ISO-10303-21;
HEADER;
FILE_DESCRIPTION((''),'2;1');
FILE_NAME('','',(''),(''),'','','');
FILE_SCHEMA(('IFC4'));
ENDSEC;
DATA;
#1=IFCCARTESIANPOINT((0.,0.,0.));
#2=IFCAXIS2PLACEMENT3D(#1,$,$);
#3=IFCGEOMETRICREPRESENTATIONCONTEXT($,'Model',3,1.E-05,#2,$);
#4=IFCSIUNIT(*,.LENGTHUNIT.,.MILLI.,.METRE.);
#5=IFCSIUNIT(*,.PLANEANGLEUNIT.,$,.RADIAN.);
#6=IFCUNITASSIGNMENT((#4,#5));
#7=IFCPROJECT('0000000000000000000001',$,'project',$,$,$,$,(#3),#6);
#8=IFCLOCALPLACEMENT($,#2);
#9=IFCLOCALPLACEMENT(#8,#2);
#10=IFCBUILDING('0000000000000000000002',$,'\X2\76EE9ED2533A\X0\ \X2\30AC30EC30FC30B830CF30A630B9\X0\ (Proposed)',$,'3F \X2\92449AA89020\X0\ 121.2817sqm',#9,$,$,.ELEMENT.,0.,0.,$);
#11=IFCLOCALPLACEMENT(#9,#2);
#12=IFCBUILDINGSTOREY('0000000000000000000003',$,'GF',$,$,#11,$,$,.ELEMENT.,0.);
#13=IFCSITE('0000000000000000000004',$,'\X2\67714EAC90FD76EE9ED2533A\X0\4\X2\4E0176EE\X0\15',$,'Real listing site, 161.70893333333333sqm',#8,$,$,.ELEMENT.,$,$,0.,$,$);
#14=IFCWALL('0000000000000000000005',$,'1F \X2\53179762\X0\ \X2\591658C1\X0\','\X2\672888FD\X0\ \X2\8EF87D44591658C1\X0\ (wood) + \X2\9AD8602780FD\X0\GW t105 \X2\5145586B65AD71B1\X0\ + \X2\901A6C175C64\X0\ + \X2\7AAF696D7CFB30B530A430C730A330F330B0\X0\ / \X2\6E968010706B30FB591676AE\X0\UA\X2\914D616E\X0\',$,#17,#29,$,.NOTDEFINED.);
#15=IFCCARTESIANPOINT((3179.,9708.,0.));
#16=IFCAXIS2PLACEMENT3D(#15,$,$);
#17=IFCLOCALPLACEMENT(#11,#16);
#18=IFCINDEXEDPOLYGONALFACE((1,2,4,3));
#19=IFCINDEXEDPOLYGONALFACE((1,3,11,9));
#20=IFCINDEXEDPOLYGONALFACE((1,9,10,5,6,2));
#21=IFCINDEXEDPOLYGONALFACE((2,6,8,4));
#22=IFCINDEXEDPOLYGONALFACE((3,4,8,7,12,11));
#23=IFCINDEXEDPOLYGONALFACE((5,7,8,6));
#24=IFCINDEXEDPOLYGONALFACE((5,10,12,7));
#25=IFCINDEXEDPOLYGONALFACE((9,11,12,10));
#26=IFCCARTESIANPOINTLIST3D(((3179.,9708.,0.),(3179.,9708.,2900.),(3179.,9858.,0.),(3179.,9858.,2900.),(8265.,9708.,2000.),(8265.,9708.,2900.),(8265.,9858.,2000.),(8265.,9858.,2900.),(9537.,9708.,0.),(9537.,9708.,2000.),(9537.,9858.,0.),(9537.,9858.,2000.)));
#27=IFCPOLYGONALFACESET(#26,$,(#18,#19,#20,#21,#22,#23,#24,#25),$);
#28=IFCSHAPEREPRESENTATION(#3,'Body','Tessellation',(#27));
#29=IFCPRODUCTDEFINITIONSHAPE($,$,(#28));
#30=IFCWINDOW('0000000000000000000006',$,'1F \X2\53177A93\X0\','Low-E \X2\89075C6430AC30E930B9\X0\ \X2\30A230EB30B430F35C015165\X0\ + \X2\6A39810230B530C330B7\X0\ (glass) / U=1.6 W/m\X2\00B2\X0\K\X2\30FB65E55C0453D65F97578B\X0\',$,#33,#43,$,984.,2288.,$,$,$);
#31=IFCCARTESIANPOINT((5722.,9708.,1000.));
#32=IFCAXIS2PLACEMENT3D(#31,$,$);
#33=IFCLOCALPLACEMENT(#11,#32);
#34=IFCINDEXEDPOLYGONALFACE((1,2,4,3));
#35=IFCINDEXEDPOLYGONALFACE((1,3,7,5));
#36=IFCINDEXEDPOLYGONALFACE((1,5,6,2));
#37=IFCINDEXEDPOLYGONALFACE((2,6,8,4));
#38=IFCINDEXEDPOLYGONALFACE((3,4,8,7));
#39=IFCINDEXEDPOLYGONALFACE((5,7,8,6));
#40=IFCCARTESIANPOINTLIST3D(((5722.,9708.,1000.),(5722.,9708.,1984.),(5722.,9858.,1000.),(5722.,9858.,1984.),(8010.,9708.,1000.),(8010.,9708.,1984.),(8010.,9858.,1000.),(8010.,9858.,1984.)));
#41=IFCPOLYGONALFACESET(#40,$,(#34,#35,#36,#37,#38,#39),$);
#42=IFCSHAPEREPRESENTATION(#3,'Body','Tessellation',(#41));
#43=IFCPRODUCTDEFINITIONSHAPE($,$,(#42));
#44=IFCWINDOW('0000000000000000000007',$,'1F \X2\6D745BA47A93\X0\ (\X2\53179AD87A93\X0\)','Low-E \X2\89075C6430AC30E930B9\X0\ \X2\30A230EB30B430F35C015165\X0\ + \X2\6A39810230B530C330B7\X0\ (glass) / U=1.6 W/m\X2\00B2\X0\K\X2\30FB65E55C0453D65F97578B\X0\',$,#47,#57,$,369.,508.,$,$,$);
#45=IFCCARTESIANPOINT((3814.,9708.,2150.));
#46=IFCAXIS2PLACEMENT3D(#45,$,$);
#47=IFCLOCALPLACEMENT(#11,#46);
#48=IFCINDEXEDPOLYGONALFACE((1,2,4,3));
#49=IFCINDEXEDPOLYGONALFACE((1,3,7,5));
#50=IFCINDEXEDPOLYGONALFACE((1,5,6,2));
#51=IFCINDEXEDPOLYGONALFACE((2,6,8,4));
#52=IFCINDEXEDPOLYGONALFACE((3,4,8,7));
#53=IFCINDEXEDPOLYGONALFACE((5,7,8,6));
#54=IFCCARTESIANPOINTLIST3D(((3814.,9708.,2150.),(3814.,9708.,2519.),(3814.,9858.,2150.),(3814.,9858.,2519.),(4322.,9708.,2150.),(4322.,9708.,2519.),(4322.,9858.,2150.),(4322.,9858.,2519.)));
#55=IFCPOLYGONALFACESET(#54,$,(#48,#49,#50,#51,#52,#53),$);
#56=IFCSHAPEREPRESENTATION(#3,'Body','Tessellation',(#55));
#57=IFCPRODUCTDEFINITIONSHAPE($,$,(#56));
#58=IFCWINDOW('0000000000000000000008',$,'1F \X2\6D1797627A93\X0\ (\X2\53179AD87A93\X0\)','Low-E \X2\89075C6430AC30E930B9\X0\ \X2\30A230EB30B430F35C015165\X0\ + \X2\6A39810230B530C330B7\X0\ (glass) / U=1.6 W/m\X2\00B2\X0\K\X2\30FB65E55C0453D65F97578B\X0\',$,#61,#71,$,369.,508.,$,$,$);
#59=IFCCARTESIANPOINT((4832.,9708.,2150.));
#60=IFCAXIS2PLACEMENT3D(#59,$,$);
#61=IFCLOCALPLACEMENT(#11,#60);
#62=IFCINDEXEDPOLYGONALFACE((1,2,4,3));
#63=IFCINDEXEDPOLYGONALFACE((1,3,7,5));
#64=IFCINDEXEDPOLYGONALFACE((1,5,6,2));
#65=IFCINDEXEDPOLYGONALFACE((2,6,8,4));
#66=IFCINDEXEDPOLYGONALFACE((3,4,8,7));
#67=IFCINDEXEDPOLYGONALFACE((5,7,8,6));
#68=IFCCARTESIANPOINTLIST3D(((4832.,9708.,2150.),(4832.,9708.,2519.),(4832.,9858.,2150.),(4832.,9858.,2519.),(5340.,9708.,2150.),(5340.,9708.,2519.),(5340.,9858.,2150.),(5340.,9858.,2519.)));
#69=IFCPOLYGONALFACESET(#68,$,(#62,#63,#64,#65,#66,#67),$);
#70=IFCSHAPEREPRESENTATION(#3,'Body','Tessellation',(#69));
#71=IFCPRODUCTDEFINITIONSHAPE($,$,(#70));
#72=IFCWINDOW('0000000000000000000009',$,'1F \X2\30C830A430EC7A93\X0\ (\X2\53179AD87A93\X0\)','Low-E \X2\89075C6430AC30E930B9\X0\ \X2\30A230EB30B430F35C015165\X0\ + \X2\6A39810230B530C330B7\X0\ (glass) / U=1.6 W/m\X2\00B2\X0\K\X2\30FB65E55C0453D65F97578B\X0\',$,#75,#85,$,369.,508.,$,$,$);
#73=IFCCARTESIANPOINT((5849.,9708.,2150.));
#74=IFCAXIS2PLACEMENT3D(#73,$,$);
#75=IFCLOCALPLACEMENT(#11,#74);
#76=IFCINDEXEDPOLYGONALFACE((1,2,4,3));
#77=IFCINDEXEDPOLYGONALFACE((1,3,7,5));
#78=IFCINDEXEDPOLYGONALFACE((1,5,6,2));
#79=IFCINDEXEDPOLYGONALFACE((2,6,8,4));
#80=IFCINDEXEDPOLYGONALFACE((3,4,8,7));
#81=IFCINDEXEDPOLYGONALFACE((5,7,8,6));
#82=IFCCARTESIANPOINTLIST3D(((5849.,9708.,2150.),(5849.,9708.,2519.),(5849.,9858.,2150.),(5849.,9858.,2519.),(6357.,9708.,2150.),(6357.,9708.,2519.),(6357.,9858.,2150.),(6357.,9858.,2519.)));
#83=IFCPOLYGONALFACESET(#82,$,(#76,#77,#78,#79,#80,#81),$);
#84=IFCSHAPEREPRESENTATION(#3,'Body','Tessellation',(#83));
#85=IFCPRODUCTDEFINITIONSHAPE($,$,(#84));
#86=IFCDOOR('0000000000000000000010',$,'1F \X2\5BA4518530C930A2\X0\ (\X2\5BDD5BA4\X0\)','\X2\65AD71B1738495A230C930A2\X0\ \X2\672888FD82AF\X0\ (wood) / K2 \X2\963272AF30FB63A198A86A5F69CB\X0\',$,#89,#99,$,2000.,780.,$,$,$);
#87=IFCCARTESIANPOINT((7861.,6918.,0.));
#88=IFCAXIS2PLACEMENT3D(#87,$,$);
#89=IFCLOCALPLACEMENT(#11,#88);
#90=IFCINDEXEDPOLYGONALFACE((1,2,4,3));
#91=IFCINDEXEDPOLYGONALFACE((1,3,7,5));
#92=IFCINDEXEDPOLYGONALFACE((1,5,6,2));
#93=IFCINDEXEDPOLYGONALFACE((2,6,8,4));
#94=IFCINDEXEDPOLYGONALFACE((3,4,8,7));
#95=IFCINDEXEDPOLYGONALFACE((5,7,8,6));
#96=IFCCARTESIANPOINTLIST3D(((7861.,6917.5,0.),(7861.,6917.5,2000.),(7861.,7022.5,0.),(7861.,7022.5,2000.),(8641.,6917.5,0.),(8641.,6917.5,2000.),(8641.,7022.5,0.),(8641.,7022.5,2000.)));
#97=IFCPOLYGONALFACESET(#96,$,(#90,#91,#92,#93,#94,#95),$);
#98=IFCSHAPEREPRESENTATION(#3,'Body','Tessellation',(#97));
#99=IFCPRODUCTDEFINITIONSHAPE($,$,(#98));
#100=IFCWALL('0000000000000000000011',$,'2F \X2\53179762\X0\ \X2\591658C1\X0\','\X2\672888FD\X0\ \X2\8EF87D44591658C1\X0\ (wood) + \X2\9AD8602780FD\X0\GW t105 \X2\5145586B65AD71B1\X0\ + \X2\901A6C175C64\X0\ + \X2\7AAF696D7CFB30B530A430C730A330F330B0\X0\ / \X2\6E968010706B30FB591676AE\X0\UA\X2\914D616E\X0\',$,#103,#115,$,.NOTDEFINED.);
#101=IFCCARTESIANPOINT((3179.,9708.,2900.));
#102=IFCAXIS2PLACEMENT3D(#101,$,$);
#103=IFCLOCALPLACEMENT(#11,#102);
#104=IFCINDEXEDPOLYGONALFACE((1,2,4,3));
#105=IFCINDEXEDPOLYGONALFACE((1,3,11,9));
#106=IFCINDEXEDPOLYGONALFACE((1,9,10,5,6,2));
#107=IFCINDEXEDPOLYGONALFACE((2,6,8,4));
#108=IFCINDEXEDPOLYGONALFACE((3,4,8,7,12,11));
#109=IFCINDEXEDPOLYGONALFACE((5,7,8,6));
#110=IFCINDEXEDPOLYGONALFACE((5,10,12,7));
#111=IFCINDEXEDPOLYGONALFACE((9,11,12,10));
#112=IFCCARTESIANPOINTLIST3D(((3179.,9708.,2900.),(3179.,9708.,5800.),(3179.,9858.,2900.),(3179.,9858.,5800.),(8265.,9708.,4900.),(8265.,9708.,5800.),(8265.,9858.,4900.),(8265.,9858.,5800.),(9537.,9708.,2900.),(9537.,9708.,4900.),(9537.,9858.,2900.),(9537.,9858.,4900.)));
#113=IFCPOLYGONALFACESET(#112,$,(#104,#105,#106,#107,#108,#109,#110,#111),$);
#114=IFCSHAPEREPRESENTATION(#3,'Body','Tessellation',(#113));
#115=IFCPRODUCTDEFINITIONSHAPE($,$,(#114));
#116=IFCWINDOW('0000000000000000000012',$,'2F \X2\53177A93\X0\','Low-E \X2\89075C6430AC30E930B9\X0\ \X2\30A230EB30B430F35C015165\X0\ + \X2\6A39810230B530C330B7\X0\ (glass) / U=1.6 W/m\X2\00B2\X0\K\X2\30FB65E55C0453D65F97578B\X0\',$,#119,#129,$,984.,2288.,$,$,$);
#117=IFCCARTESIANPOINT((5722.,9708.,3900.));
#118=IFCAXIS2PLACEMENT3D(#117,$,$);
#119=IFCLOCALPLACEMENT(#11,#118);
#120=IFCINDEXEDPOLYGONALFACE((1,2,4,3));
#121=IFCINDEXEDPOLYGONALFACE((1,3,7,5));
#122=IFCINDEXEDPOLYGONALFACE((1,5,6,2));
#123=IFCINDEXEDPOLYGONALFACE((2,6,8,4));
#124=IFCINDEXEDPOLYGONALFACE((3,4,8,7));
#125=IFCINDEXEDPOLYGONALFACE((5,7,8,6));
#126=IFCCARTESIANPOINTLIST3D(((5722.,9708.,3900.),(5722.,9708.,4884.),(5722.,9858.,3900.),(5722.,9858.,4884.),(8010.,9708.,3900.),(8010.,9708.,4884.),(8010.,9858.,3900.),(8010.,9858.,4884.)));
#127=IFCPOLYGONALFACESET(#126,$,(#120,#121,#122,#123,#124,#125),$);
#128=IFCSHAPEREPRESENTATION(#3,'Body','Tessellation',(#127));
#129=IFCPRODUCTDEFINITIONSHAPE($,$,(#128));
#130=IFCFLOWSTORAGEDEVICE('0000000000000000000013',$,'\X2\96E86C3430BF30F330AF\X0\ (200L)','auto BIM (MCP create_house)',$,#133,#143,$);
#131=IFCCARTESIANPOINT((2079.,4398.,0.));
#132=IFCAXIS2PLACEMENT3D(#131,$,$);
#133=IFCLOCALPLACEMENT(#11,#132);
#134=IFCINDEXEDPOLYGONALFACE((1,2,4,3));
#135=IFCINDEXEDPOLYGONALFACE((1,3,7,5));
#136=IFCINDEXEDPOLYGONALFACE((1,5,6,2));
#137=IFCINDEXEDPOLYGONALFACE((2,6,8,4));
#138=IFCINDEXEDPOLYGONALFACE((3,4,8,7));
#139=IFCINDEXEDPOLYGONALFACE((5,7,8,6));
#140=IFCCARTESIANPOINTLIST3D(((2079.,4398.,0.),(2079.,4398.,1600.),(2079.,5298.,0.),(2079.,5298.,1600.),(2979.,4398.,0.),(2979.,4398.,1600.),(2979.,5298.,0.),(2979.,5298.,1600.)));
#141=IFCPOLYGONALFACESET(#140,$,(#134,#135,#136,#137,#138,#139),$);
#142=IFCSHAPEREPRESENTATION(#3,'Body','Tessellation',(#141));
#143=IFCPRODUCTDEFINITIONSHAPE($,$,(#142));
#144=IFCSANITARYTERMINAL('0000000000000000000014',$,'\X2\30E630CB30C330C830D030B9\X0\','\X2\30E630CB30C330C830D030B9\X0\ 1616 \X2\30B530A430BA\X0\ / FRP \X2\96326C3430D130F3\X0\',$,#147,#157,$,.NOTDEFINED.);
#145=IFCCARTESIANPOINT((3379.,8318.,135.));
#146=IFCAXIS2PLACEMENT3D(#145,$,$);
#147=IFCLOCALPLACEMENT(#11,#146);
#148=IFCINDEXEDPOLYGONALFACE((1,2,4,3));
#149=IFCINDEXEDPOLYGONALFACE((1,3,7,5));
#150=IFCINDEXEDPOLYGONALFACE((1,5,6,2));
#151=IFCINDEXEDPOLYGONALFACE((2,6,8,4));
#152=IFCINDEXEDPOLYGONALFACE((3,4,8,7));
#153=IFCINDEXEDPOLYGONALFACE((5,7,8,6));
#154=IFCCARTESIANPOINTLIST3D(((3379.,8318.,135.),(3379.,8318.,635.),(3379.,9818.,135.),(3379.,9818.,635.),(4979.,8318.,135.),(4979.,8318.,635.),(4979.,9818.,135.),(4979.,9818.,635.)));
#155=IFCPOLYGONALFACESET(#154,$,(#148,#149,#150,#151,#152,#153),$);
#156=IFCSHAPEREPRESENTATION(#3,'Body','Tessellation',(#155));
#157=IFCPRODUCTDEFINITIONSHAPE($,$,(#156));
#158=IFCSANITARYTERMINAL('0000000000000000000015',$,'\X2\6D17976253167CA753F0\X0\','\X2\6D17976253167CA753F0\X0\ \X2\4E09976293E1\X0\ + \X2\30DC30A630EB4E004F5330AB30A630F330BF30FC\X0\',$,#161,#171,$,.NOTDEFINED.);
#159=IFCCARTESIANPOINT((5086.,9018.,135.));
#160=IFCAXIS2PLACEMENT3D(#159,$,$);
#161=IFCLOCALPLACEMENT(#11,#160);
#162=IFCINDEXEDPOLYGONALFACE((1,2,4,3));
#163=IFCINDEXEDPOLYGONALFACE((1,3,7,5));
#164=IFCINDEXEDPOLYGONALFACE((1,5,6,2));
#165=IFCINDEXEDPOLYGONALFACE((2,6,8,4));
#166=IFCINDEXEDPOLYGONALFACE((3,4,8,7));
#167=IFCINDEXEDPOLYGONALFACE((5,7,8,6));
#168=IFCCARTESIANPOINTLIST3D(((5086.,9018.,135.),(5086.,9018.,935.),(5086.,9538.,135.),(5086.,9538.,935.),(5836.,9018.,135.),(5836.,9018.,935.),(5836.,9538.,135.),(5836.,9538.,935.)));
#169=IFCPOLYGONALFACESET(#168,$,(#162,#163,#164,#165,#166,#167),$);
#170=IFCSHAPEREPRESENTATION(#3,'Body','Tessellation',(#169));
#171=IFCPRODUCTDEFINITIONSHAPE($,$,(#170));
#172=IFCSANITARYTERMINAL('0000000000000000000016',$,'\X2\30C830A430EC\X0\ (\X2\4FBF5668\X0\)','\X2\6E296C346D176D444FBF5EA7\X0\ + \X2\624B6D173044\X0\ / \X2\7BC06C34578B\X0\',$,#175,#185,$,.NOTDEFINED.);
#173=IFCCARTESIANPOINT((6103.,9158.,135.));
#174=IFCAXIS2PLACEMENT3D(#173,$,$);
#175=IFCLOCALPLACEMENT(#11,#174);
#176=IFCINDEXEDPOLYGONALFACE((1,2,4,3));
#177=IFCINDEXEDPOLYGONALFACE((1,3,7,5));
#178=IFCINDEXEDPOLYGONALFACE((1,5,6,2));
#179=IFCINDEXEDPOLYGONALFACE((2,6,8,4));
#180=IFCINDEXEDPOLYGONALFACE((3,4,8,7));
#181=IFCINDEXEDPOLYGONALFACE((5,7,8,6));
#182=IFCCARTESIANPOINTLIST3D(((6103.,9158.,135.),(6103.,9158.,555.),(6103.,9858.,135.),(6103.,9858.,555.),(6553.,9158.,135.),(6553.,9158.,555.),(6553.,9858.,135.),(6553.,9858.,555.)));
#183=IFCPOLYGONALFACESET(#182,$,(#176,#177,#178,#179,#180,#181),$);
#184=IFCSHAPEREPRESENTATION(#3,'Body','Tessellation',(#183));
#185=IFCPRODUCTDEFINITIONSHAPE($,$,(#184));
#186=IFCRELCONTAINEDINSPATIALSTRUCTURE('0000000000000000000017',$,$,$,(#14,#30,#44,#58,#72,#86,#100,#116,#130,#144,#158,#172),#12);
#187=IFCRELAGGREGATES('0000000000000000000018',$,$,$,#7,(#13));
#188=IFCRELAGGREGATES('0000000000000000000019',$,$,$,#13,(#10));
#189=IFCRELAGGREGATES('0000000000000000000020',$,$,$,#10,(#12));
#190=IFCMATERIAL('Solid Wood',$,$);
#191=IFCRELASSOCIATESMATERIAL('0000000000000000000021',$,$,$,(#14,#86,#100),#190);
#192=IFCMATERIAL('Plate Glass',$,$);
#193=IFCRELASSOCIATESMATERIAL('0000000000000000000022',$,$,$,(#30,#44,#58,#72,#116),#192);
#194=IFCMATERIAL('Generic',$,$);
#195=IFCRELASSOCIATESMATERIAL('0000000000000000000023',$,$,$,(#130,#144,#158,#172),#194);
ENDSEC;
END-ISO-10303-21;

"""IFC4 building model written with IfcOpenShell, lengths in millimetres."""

from ifc_helpers import new_model, si_unit, frame, frame_2d, origin, place, context, project, spatial, rectangle, extrude, material, element, fill, save


model = new_model("IFC4")

# Units and contexts
model_context = context("Model", 3, precision=1e-05, world=origin())
ifc_project = project(units=[si_unit("LENGTHUNIT", "METRE", prefix="MILLI"), si_unit("PLANEANGLEUNIT", "RADIAN")], contexts=[model_context])

# Site, building, storey
site_placement = place(None, origin())
site = spatial("IfcSite", under=ifc_project, at=site_placement, Name="東京都目黒区4丁目15", ObjectType="Real listing site, 161.70893333333333sqm", CompositionType="ELEMENT", RefElevation=0.0)
building_placement = place(site_placement, origin())
building = spatial("IfcBuilding", under=site, at=building_placement, Name="目黒区 ガレージハウス (Proposed)", ObjectType="3F 鉄骨造 121.2817sqm", CompositionType="ELEMENT", ElevationOfRefHeight=0.0, ElevationOfTerrain=0.0)
storey_placement = place(building_placement, origin())
storey = spatial("IfcBuildingStorey", under=building, at=storey_placement, Name="GF", CompositionType="ELEMENT", Elevation=0.0)

# Wall, openings, windows
ifc_material_1 = material(Name="Solid Wood")
wall_1_placement = place(storey_placement, frame((3179.0, 9708.0, 0.0)))
wall_1 = element("IfcWall", 1, at=wall_1_placement, inside=storey, material=ifc_material_1, Name="1F 北面 外壁", Description="木製 軸組外壁 (wood) + 高性能GW t105 充填断熱 + 通気層 + 窯業系サイディング / 準耐火・外皮UA配慮", PredefinedType="NOTDEFINED", context=model_context, shape_type="SweptSolid", body=[
    extrude(rectangle(XDim=6358.0, YDim=150.0, at=frame_2d((3179.0, 75.0))), frame((3179.0, 9708.0, 0.0)), (0.0, 0.0, 1.0), 2900.0),
])
opening_1_placement = place(storey_placement, frame((5722.0, 9708.0, 1000.0)))
opening_1 = element("IfcOpeningElement", 2, at=opening_1_placement, cuts=wall_1, PredefinedType="NOTDEFINED", context=model_context, shape_type="SweptSolid", body=[
    extrude(rectangle(XDim=2288.0, YDim=150.0, at=frame_2d((1144.0, 75.0))), frame((5722.0, 9708.0, 1000.0)), (0.0, 0.0, 1.0), 984.0),
])
opening_2_placement = place(storey_placement, frame((3814.0, 9708.0, 2150.0)))
opening_2 = element("IfcOpeningElement", 3, at=opening_2_placement, cuts=wall_1, PredefinedType="NOTDEFINED", context=model_context, shape_type="SweptSolid", body=[
    extrude(rectangle(XDim=508.0, YDim=150.0, at=frame_2d((254.0, 75.0))), frame((3814.0, 9708.0, 2150.0)), (0.0, 0.0, 1.0), 369.0),
])
opening_3_placement = place(storey_placement, frame((4832.0, 9708.0, 2150.0)))
opening_3 = element("IfcOpeningElement", 4, at=opening_3_placement, cuts=wall_1, PredefinedType="NOTDEFINED", context=model_context, shape_type="SweptSolid", body=[
    extrude(rectangle(XDim=508.0, YDim=150.0, at=frame_2d((254.0, 75.0))), frame((4832.0, 9708.0, 2150.0)), (0.0, 0.0, 1.0), 369.0),
])
opening_4_placement = place(storey_placement, frame((5849.0, 9708.0, 2150.0)))
opening_4 = element("IfcOpeningElement", 5, at=opening_4_placement, cuts=wall_1, PredefinedType="NOTDEFINED", context=model_context, shape_type="SweptSolid", body=[
    extrude(rectangle(XDim=508.0, YDim=150.0, at=frame_2d((254.0, 75.0))), frame((5849.0, 9708.0, 2150.0)), (0.0, 0.0, 1.0), 369.0),
])
ifc_material_2 = material(Name="Plate Glass")
window_1_placement = place(storey_placement, frame((5722.0, 9708.0, 1000.0)))
window_1 = element("IfcWindow", 6, at=window_1_placement, inside=storey, material=ifc_material_2, Name="1F 北窓", Description="Low-E 複層ガラス アルゴン封入 + 樹脂サッシ (glass) / U=1.6 W/m²K・日射取得型", OverallHeight=984.0, OverallWidth=2288.0, context=model_context, shape_type="SweptSolid", body=[
    extrude(rectangle(XDim=2288.0, YDim=150.0, at=frame_2d((1144.0, 75.0))), frame((5722.0, 9708.0, 1000.0)), (0.0, 0.0, 1.0), 984.0),
])
fill(opening_1, window_1)
window_2_placement = place(storey_placement, frame((3814.0, 9708.0, 2150.0)))
window_2 = element("IfcWindow", 7, at=window_2_placement, inside=storey, material=ifc_material_2, Name="1F 浴室窓 (北高窓)", Description="Low-E 複層ガラス アルゴン封入 + 樹脂サッシ (glass) / U=1.6 W/m²K・日射取得型", OverallHeight=369.0, OverallWidth=508.0, context=model_context, shape_type="SweptSolid", body=[
    extrude(rectangle(XDim=508.0, YDim=150.0, at=frame_2d((254.0, 75.0))), frame((3814.0, 9708.0, 2150.0)), (0.0, 0.0, 1.0), 369.0),
])
fill(opening_2, window_2)
window_3_placement = place(storey_placement, frame((4832.0, 9708.0, 2150.0)))
window_3 = element("IfcWindow", 8, at=window_3_placement, inside=storey, material=ifc_material_2, Name="1F 洗面窓 (北高窓)", Description="Low-E 複層ガラス アルゴン封入 + 樹脂サッシ (glass) / U=1.6 W/m²K・日射取得型", OverallHeight=369.0, OverallWidth=508.0, context=model_context, shape_type="SweptSolid", body=[
    extrude(rectangle(XDim=508.0, YDim=150.0, at=frame_2d((254.0, 75.0))), frame((4832.0, 9708.0, 2150.0)), (0.0, 0.0, 1.0), 369.0),
])
fill(opening_3, window_3)
window_4_placement = place(storey_placement, frame((5849.0, 9708.0, 2150.0)))
window_4 = element("IfcWindow", 9, at=window_4_placement, inside=storey, material=ifc_material_2, Name="1F トイレ窓 (北高窓)", Description="Low-E 複層ガラス アルゴン封入 + 樹脂サッシ (glass) / U=1.6 W/m²K・日射取得型", OverallHeight=369.0, OverallWidth=508.0, context=model_context, shape_type="SweptSolid", body=[
    extrude(rectangle(XDim=508.0, YDim=150.0, at=frame_2d((254.0, 75.0))), frame((5849.0, 9708.0, 2150.0)), (0.0, 0.0, 1.0), 369.0),
])
fill(opening_4, window_4)

# Door
door_1_placement = place(storey_placement, frame((7861.0, 6918.0, 0.0)))
element("IfcDoor", 10, at=door_1_placement, inside=storey, material=ifc_material_1, Name="1F 室内ドア (寝室)", Description="断熱玄関ドア 木製芯 (wood) / K2 防犯・採風機構", OverallHeight=2000.0, OverallWidth=780.0, context=model_context, shape_type="SweptSolid", body=[
    extrude(rectangle(XDim=780.0, YDim=105.0, at=frame_2d((390.0, 52.0))), frame((7861.0, 6918.0, 0.0)), (0.0, 0.0, 1.0), 2000.0),
])

# Wall, opening, window
wall_2_placement = place(storey_placement, frame((3179.0, 9708.0, 2900.0)))
wall_2 = element("IfcWall", 11, at=wall_2_placement, inside=storey, material=ifc_material_1, Name="2F 北面 外壁", Description="木製 軸組外壁 (wood) + 高性能GW t105 充填断熱 + 通気層 + 窯業系サイディング / 準耐火・外皮UA配慮", PredefinedType="NOTDEFINED", context=model_context, shape_type="SweptSolid", body=[
    extrude(rectangle(XDim=6358.0, YDim=150.0, at=frame_2d((3179.0, 75.0))), frame((3179.0, 9708.0, 2900.0)), (0.0, 0.0, 1.0), 2900.0),
])
opening_5_placement = place(storey_placement, frame((5722.0, 9708.0, 3900.0)))
opening_5 = element("IfcOpeningElement", 12, at=opening_5_placement, cuts=wall_2, PredefinedType="NOTDEFINED", context=model_context, shape_type="SweptSolid", body=[
    extrude(rectangle(XDim=2288.0, YDim=150.0, at=frame_2d((1144.0, 75.0))), frame((5722.0, 9708.0, 3900.0)), (0.0, 0.0, 1.0), 984.0),
])
window_5_placement = place(storey_placement, frame((5722.0, 9708.0, 3900.0)))
window_5 = element("IfcWindow", 13, at=window_5_placement, inside=storey, material=ifc_material_2, Name="2F 北窓", Description="Low-E 複層ガラス アルゴン封入 + 樹脂サッシ (glass) / U=1.6 W/m²K・日射取得型", OverallHeight=984.0, OverallWidth=2288.0, context=model_context, shape_type="SweptSolid", body=[
    extrude(rectangle(XDim=2288.0, YDim=150.0, at=frame_2d((1144.0, 75.0))), frame((5722.0, 9708.0, 3900.0)), (0.0, 0.0, 1.0), 984.0),
])
fill(opening_5, window_5)

# Flow storage device
ifc_material_3 = material(Name="Generic")
flow_storage_device_placement = place(storey_placement, frame((2079.0, 4398.0, 0.0)))
element("IfcFlowStorageDevice", 14, at=flow_storage_device_placement, inside=storey, material=ifc_material_3, Name="雨水タンク (200L)", Description="auto BIM (MCP create_house)", context=model_context, shape_type="SweptSolid", body=[
    extrude(rectangle(XDim=900.0, YDim=900.0, at=frame_2d((450.0, 450.0))), frame((2079.0, 4398.0, 0.0)), (0.0, 0.0, 1.0), 1600.0),
])

# Sanitary terminals
sanitary_terminal_1_placement = place(storey_placement, frame((3379.0, 8318.0, 135.0)))
element("IfcSanitaryTerminal", 15, at=sanitary_terminal_1_placement, inside=storey, material=ifc_material_3, Name="ユニットバス", Description="ユニットバス 1616 サイズ / FRP 防水パン", PredefinedType="NOTDEFINED", context=model_context, shape_type="SweptSolid", body=[
    extrude(rectangle(XDim=1600.0, YDim=1500.0, at=frame_2d((800.0, 750.0))), frame((3379.0, 8318.0, 135.0)), (0.0, 0.0, 1.0), 500.0),
])
sanitary_terminal_2_placement = place(storey_placement, frame((5086.0, 9018.0, 135.0)))
element("IfcSanitaryTerminal", 16, at=sanitary_terminal_2_placement, inside=storey, material=ifc_material_3, Name="洗面化粧台", Description="洗面化粧台 三面鏡 + ボウル一体カウンター", PredefinedType="NOTDEFINED", context=model_context, shape_type="SweptSolid", body=[
    extrude(rectangle(XDim=750.0, YDim=520.0, at=frame_2d((375.0, 260.0))), frame((5086.0, 9018.0, 135.0)), (0.0, 0.0, 1.0), 800.0),
])
sanitary_terminal_3_placement = place(storey_placement, frame((6103.0, 9158.0, 135.0)))
element("IfcSanitaryTerminal", 17, at=sanitary_terminal_3_placement, inside=storey, material=ifc_material_3, Name="トイレ (便器)", Description="温水洗浄便座 + 手洗い / 節水型", PredefinedType="NOTDEFINED", context=model_context, shape_type="SweptSolid", body=[
    extrude(rectangle(XDim=450.0, YDim=700.0, at=frame_2d((225.0, 350.0))), frame((6103.0, 9158.0, 135.0)), (0.0, 0.0, 1.0), 420.0),
])

save(model, "model.ifc")
